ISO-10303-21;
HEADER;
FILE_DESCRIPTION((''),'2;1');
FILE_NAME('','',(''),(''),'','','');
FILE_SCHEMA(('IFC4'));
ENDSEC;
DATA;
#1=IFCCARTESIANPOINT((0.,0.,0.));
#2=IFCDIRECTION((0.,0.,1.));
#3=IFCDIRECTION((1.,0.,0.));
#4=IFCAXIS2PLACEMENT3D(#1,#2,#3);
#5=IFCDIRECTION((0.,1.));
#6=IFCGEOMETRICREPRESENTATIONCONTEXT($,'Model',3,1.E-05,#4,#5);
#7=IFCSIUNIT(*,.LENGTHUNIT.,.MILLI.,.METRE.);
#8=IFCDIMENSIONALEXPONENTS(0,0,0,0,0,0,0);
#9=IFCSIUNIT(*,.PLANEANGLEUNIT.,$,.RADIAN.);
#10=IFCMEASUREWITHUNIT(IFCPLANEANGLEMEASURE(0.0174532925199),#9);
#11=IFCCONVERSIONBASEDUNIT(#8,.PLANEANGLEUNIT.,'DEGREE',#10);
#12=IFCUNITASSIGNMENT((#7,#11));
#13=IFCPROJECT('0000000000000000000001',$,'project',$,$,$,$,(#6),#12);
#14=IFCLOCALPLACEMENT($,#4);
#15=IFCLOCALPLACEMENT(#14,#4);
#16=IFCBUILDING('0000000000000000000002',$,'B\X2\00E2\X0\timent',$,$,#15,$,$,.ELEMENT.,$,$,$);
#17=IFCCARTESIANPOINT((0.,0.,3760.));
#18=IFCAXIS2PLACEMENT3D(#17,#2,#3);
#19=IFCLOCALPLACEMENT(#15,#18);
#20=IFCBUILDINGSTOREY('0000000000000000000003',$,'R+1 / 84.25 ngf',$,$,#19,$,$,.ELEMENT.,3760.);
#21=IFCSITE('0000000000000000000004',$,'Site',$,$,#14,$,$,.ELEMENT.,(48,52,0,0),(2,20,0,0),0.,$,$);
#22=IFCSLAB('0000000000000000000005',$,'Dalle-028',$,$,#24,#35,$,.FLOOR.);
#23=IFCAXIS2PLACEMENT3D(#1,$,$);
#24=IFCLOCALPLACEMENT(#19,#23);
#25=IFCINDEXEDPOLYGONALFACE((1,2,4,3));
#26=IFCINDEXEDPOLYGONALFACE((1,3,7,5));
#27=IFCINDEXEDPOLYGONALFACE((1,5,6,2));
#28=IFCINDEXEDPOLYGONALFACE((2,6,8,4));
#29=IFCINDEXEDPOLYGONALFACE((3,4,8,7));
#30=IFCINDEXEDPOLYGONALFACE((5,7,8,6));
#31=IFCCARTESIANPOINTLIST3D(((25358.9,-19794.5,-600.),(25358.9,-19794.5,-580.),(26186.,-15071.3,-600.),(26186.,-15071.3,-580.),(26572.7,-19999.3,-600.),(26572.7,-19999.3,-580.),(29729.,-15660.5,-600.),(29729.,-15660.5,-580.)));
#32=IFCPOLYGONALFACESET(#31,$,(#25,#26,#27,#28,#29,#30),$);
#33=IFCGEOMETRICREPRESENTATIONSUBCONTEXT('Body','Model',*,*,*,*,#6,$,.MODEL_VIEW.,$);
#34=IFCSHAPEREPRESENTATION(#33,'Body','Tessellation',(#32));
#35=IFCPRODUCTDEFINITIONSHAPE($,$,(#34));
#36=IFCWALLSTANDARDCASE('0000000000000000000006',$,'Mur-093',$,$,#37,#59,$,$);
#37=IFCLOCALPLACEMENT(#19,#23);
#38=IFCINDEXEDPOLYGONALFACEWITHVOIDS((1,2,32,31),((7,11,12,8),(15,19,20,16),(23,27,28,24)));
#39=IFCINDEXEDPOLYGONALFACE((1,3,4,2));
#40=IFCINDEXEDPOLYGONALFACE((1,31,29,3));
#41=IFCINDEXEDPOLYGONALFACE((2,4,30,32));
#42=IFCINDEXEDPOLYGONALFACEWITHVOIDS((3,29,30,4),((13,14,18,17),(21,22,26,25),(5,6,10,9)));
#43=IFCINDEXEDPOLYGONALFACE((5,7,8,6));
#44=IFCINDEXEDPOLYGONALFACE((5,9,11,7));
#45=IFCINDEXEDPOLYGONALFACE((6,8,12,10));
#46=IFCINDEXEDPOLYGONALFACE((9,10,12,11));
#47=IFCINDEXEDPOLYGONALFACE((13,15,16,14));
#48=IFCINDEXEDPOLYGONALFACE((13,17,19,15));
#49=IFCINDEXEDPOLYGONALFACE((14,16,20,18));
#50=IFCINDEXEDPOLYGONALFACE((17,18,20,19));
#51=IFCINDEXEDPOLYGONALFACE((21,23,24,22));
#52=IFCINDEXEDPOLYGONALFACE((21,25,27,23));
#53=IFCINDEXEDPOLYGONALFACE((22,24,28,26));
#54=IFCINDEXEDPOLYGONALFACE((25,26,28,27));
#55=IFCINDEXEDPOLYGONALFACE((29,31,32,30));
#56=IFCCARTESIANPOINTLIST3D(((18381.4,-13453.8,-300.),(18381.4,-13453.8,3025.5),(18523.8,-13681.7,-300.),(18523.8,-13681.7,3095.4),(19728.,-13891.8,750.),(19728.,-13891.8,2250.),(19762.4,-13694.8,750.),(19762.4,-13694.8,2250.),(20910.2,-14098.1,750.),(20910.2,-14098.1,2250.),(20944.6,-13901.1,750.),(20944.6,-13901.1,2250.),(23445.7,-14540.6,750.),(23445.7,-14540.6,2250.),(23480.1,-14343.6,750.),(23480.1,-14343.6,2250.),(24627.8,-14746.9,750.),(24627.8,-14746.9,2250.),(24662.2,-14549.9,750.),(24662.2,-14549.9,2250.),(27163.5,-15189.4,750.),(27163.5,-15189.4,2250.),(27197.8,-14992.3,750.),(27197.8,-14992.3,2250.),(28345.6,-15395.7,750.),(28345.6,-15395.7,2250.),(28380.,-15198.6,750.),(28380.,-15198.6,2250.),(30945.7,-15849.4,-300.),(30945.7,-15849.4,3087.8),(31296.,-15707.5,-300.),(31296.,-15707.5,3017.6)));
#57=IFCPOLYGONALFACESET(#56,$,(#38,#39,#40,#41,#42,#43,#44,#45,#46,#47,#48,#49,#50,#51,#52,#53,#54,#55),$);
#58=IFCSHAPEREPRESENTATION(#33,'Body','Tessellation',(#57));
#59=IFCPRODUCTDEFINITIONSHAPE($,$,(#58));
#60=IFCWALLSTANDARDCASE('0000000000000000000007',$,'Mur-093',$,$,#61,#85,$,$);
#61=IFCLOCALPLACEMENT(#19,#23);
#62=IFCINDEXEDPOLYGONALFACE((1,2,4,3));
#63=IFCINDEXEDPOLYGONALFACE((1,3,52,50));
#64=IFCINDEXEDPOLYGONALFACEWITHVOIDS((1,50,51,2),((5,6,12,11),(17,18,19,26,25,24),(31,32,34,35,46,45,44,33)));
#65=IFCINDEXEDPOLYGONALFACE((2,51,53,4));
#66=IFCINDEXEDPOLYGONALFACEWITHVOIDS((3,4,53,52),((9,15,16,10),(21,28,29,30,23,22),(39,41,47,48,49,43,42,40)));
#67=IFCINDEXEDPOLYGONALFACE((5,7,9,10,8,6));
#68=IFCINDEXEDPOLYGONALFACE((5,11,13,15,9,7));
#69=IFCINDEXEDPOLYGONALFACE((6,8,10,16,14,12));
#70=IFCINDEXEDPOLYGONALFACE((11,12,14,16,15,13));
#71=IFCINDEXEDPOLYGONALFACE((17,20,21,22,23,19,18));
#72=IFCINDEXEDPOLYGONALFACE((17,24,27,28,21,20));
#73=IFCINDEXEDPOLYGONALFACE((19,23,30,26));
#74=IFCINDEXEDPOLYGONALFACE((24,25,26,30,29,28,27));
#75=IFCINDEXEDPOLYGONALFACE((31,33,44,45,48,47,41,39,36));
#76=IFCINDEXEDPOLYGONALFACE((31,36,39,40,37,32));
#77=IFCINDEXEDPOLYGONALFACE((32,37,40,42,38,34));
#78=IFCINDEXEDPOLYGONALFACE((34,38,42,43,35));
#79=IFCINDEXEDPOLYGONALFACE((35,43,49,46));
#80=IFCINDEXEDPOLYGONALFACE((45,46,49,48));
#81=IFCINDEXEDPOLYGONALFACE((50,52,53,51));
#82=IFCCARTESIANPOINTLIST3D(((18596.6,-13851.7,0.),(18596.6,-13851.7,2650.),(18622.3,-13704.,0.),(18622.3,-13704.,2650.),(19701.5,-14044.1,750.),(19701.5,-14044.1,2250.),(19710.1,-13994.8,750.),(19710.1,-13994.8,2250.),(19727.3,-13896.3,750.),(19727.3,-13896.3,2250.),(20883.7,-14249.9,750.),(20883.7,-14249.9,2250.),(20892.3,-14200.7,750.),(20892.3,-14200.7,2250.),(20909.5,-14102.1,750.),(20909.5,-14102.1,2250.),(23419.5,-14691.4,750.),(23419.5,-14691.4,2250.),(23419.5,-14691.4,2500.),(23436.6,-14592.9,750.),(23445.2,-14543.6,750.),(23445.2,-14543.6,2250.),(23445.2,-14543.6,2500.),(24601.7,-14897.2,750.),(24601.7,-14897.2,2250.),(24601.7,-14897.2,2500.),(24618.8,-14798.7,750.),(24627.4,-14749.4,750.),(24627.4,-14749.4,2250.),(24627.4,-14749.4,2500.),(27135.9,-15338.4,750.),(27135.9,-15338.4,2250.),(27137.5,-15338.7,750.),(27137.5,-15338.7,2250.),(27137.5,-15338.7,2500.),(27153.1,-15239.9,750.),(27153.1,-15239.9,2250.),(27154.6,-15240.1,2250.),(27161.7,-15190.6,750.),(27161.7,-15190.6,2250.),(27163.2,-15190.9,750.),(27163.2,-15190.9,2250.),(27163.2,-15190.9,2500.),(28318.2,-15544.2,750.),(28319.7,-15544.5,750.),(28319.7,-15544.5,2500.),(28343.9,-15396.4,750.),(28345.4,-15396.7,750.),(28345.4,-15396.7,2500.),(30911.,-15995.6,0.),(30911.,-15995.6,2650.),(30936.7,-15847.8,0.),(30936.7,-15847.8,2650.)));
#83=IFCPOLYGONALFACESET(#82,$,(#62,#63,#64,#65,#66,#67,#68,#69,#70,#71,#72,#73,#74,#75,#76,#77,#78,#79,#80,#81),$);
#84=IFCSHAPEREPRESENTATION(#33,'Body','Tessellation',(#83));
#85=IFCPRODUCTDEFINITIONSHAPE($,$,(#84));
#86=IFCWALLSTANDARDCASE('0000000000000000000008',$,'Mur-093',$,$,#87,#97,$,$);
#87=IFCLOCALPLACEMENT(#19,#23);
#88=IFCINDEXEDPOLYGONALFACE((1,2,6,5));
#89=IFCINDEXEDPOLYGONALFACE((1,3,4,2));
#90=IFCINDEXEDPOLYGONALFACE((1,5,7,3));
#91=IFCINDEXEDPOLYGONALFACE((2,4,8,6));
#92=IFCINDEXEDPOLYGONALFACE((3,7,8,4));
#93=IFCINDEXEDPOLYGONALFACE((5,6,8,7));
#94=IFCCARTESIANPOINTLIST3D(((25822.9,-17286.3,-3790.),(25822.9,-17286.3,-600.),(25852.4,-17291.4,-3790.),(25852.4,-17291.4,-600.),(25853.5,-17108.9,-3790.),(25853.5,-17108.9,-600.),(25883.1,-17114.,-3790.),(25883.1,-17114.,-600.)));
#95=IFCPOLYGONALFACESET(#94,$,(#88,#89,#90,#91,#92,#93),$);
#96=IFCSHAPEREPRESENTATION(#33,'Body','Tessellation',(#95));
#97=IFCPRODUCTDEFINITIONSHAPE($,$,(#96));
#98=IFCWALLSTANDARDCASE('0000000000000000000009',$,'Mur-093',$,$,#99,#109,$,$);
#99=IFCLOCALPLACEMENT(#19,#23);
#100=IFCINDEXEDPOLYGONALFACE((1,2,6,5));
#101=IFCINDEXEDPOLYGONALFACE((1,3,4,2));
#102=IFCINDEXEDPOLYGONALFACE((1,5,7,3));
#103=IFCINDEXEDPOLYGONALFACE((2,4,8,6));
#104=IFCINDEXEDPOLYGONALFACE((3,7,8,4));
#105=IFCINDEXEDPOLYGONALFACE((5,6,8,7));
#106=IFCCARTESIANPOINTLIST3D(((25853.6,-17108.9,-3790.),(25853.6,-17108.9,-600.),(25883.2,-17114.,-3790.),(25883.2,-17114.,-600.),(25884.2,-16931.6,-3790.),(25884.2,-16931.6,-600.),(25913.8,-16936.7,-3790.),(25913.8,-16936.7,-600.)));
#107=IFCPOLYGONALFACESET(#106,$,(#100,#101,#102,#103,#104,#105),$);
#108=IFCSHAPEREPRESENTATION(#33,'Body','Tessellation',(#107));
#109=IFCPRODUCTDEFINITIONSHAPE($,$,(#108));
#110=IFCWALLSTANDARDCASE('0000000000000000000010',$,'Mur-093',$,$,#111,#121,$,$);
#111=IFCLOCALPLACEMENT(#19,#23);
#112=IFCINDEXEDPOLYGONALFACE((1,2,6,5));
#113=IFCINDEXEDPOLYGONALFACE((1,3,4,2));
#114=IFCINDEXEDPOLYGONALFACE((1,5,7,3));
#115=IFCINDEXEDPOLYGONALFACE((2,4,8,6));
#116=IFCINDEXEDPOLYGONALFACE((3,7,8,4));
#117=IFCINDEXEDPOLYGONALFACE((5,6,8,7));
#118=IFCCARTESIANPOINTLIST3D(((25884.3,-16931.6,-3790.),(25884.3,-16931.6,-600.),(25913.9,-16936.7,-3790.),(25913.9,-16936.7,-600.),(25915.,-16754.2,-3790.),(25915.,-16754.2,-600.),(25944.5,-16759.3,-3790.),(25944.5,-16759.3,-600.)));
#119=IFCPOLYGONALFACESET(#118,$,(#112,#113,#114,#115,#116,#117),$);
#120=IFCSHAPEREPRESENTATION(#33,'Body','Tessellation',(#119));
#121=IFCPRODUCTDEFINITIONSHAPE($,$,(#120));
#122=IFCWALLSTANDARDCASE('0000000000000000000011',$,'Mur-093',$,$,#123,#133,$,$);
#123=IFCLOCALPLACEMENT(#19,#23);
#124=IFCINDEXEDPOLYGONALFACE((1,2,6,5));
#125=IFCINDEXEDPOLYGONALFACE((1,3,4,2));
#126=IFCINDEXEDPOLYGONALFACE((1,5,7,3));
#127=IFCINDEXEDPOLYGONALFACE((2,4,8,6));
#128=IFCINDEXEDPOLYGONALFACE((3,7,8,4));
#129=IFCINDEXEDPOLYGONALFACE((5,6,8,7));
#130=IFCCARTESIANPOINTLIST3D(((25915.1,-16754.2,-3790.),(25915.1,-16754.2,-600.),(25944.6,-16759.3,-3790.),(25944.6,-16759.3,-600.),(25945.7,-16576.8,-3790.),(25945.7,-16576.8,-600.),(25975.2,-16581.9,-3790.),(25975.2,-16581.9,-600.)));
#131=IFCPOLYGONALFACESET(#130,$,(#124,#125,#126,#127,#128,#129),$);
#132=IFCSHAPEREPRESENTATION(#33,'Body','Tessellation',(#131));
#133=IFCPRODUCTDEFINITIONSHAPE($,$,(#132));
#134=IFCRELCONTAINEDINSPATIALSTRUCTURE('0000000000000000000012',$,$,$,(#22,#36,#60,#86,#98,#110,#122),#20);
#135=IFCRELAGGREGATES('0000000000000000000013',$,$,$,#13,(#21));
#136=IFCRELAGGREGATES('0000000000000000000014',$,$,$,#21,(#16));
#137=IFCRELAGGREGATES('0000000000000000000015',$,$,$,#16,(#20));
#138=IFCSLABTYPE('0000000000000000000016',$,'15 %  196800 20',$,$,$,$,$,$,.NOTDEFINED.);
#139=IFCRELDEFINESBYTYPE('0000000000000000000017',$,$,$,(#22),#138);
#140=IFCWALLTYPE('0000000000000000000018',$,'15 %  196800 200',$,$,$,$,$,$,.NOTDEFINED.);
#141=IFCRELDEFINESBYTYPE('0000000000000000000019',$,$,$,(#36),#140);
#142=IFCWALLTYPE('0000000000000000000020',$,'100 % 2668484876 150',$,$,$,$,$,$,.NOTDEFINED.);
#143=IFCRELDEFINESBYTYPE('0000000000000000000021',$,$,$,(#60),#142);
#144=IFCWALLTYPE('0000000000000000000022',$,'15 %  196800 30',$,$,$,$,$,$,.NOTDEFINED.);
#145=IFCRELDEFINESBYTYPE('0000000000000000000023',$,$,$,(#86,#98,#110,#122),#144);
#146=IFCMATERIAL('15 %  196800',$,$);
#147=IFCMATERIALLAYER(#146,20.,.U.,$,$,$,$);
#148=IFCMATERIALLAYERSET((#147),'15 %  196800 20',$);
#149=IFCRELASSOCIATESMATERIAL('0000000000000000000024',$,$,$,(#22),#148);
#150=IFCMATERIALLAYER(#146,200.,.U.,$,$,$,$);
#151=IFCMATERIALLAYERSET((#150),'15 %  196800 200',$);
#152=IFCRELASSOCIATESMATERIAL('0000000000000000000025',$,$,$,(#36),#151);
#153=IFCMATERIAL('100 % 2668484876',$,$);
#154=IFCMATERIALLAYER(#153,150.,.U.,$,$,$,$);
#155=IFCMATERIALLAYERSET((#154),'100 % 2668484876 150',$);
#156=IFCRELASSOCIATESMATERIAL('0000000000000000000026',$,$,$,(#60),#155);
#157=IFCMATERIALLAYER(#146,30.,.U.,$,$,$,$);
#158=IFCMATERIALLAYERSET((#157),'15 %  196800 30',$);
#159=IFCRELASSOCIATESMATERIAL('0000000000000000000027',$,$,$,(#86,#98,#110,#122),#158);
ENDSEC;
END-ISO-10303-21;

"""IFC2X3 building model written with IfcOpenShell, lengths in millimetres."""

from ifc_helpers import new_model, entity, si_unit, converted_unit, direction, frame, origin_with_axes, origin_2d_with_axis, place, context, subcontext, project, spatial, polyline, rectangle, outline, extrude, clip, halfspace, material, layer, layer_set, layer_usage, type_object, element, save


model = new_model("IFC2X3")

# Units and contexts
model_context = context("Model", 3, precision=1e-05, world=origin_with_axes(), true_north=direction((0.0, 1.0)))
body_context = subcontext(model_context, "Body", "Model", "MODEL_VIEW")
ifc_project = project(units=[si_unit("LENGTHUNIT", "METRE", prefix="MILLI"), converted_unit("PLANEANGLEUNIT", "DEGREE", entity("IfcPlaneAngleMeasure", 0.0174532925199), si_unit("PLANEANGLEUNIT", "RADIAN"), dimensions=[0, 0, 0, 0, 0, 0, 0])], contexts=[model_context])

# Site, building, storey
site_placement = place(None, origin_with_axes())
site = spatial("IfcSite", under=ifc_project, at=site_placement, Name="Site", CompositionType="ELEMENT", RefLatitude=(48, 52, 0, 0), RefLongitude=(2, 20, 0, 0), RefElevation=0.0)
building_placement = place(site_placement, origin_with_axes())
building = spatial("IfcBuilding", under=site, at=building_placement, Name="Bâtiment", CompositionType="ELEMENT")
storey_placement = place(building_placement, frame((0.0, 0.0, 3760.0), z_axis=(0.0, 0.0, 1.0), x_axis=(1.0, 0.0, 0.0)))
storey = spatial("IfcBuildingStorey", under=building, at=storey_placement, Name="R+1 / 84.25 ngf", CompositionType="ELEMENT", Elevation=3760.0)

# Slab
ifc_material_1 = material(Name="15 %  196800")
ifc_layer_1 = layer(ifc_material_1, 20.0, ventilated="UNKNOWN")
ifc_layer_set_1 = layer_set([ifc_layer_1], Name="15 %  196800 20")
ifc_layer_usage_1 = layer_usage(ifc_layer_set_1, "AXIS3", "NEGATIVE", 20.0)
slab_type = type_object("IfcSlabType", Name="15 %  196800 20", PredefinedType="NOTDEFINED")
slab_placement = place(storey_placement, frame((26186.0, -15071.3, -580.0), z_axis=(0.0, 0.0, 1.0), x_axis=(1.0, 0.0, 0.0)))
element("IfcSlab", 1, at=slab_placement, inside=storey, type_object=slab_type, material=ifc_layer_usage_1, Name="Dalle-028", PredefinedType="FLOOR", context=body_context, shape_type="SweptSolid", body=[
    extrude(outline(polyline([(0.0, 0.0), (-827.0, -4723.2), (386.7, -4928.0), (3543.0, -589.2), (0.0, 0.0)])), frame((0.0, 0.0, -20.0), z_axis=(0.0, 0.0, 1.0), x_axis=(1.0, 0.0, 0.0)), (0.0, 0.0, 1.0), 20.0),
])

# Walls, openings
ifc_layer_2 = layer(ifc_material_1, 200.0, ventilated="UNKNOWN")
ifc_layer_set_2 = layer_set([ifc_layer_2], Name="15 %  196800 200")
ifc_layer_usage_2 = layer_usage(ifc_layer_set_2, "AXIS2", "NEGATIVE", 200.0)
wall_type_1 = type_object("IfcWallType", Name="15 %  196800 200", PredefinedType="NOTDEFINED")
wall_1_placement = place(storey_placement, frame((31296.0, -15707.5, -300.0), z_axis=(0.0, 0.0, 1.0), x_axis=(-0.985113, 0.17191, 0.0)))
wall_1 = element("IfcWallStandardCase", 2, at=wall_1_placement, inside=storey, type_object=wall_type_1, material=ifc_layer_usage_2, Name="Mur-093", context=body_context, shape_type="Clipping", body=[
    clip(extrude(outline(polyline([(0.0, 0.0), (13109.8, 0.0), (12930.4, 200.0), (320.7, 200.0), (0.0, 0.0)])), origin_with_axes(), (0.0, 0.0, 1.0), 3440.0), halfspace(frame((-1.8, -1034.5, 2955.6), z_axis=(0.000566, 0.33035, -0.943858), x_axis=(0.0, 0.943859, 0.33035)), True)),
])
opening_1_placement = place(wall_1_placement, frame((3560.1, 0.0, 1050.0), z_axis=(0.0, 0.0, 1.0), x_axis=(1.0, 0.0, 0.0)))
element("IfcOpeningElement", 3, at=opening_1_placement, cuts=wall_1, context=body_context, shape_type="SweptSolid", body=[
    extrude(rectangle(XDim=1200.0, YDim=1500.0, at=origin_2d_with_axis()), frame((0.0, 400.0, 750.0), z_axis=(0.0, -1.0, 0.0), x_axis=(1.0, 0.0, 0.0)), (0.0, 0.0, 1.0), 600.0),
    extrude(rectangle(XDim=1500.0, YDim=1800.0, at=origin_2d_with_axis()), frame((0.0, -200.0, 750.0), z_axis=(0.0, 1.0, 0.0), x_axis=(1.0, 0.0, 0.0)), (0.0, 0.0, 1.0), 200.0),
])
opening_2_placement = place(wall_1_placement, frame((11107.9, 0.0, 1050.0), z_axis=(0.0, 0.0, 1.0), x_axis=(1.0, 0.0, 0.0)))
element("IfcOpeningElement", 4, at=opening_2_placement, cuts=wall_1, context=body_context, shape_type="SweptSolid", body=[
    extrude(rectangle(XDim=1200.0, YDim=1500.0, at=origin_2d_with_axis()), frame((0.0, 400.0, 750.0), z_axis=(0.0, -1.0, 0.0), x_axis=(1.0, 0.0, 0.0)), (0.0, 0.0, 1.0), 600.0),
    extrude(rectangle(XDim=1500.0, YDim=1800.0, at=origin_2d_with_axis()), frame((0.0, -200.0, 750.0), z_axis=(0.0, 1.0, 0.0), x_axis=(1.0, 0.0, 0.0)), (0.0, 0.0, 1.0), 200.0),
])
opening_3_placement = place(wall_1_placement, frame((7334.1, 0.0, 1050.0), z_axis=(0.0, 0.0, 1.0), x_axis=(1.0, 0.0, 0.0)))
element("IfcOpeningElement", 5, at=opening_3_placement, cuts=wall_1, context=body_context, shape_type="SweptSolid", body=[
    extrude(rectangle(XDim=1200.0, YDim=1500.0, at=origin_2d_with_axis()), frame((0.0, 400.0, 750.0), z_axis=(0.0, -1.0, 0.0), x_axis=(1.0, 0.0, 0.0)), (0.0, 0.0, 1.0), 600.0),
    extrude(rectangle(XDim=1500.0, YDim=1800.0, at=origin_2d_with_axis()), frame((0.0, -200.0, 750.0), z_axis=(0.0, 1.0, 0.0), x_axis=(1.0, 0.0, 0.0)), (0.0, 0.0, 1.0), 200.0),
])
ifc_material_2 = material(Name="100 % 2668484876")
ifc_layer_3 = layer(ifc_material_2, 150.0, ventilated="UNKNOWN")
ifc_layer_set_3 = layer_set([ifc_layer_3], Name="100 % 2668484876 150")
ifc_layer_usage_3 = layer_usage(ifc_layer_set_3, "AXIS2", "NEGATIVE", 150.0)
wall_type_2 = type_object("IfcWallType", Name="100 % 2668484876 150", PredefinedType="NOTDEFINED")
wall_2_placement = place(storey_placement, frame((30936.7, -15847.8, 0.0), z_axis=(0.0, 0.0, 1.0), x_axis=(-0.985181, 0.171516, 0.0)))
wall_2 = element("IfcWallStandardCase", 6, at=wall_2_placement, inside=storey, type_object=wall_type_2, material=ifc_layer_usage_3, Name="Mur-093", context=body_context, shape_type="SweptSolid", body=[
    extrude(outline(polyline([(0.0, 0.0), (12499.6, 0.0), (12499.6, 150.0), (0.0, 150.0), (0.0, 0.0)])), origin_with_axes(), (0.0, 0.0, 1.0), 2650.0),
])
opening_4_placement = place(wall_2_placement, frame((3231.9, 0.0, 750.0), z_axis=(0.0, 0.0, 1.0), x_axis=(1.0, 0.0, 0.0)))
element("IfcOpeningElement", 7, at=opening_4_placement, cuts=wall_2, context=body_context, shape_type="SweptSolid", body=[
    extrude(rectangle(XDim=1200.0, YDim=1500.0, at=origin_2d_with_axis()), frame((0.0, 300.0, 750.0), z_axis=(0.0, -1.0, 0.0), x_axis=(1.0, 0.0, 0.0)), (0.0, 0.0, 1.0), 250.0),
    extrude(rectangle(XDim=1200.0, YDim=1500.0, at=origin_2d_with_axis()), frame((0.0, -150.0, 750.0), z_axis=(0.0, 1.0, 0.0), x_axis=(1.0, 0.0, 0.0)), (0.0, 0.0, 1.0), 200.0),
])
opening_5_placement = place(wall_2_placement, frame((7004.2, 0.0, 750.0), z_axis=(0.0, 0.0, 1.0), x_axis=(1.0, 0.0, 0.0)))
element("IfcOpeningElement", 8, at=opening_5_placement, cuts=wall_2, context=body_context, shape_type="SweptSolid", body=[
    extrude(rectangle(XDim=1200.0, YDim=1500.0, at=origin_2d_with_axis()), frame((0.0, 300.0, 750.0), z_axis=(0.0, 1.0, 0.0), x_axis=(-1.0, 0.0, 0.0)), (0.0, 0.0, -1.0), 250.0),
    extrude(rectangle(XDim=1200.0, YDim=1500.0, at=origin_2d_with_axis()), frame((0.0, -150.0, 750.0), z_axis=(0.0, -1.0, 0.0), x_axis=(-1.0, 0.0, 0.0)), (0.0, 0.0, -1.0), 200.0),
])
opening_6_placement = place(wall_2_placement, frame((3230.3, 0.0, 750.0), z_axis=(0.0, 0.0, 1.0), x_axis=(1.0, 0.0, 0.0)))
element("IfcOpeningElement", 9, at=opening_6_placement, cuts=wall_2, context=body_context, shape_type="SweptSolid", body=[
    extrude(rectangle(XDim=1200.0, YDim=1750.0, at=origin_2d_with_axis()), frame((0.0, 300.0, 875.0), z_axis=(0.0, -1.0, 0.0), x_axis=(1.0, 0.0, 0.0)), (0.0, 0.0, 1.0), 450.0),
])
opening_7_placement = place(wall_2_placement, frame((10778.1, 0.0, 750.0), z_axis=(0.0, 0.0, 1.0), x_axis=(1.0, 0.0, 0.0)))
element("IfcOpeningElement", 10, at=opening_7_placement, cuts=wall_2, context=body_context, shape_type="SweptSolid", body=[
    extrude(rectangle(XDim=1200.0, YDim=1500.0, at=origin_2d_with_axis()), frame((0.0, -150.0, 750.0), z_axis=(0.0, 1.0, 0.0), x_axis=(1.0, 0.0, 0.0)), (0.0, 0.0, 1.0), 250.0),
    extrude(rectangle(XDim=1200.0, YDim=1500.0, at=origin_2d_with_axis()), frame((0.0, 300.0, 750.0), z_axis=(0.0, -1.0, 0.0), x_axis=(1.0, 0.0, 0.0)), (0.0, 0.0, 1.0), 200.0),
])
opening_8_placement = place(wall_2_placement, frame((7004.2, 0.0, 750.0), z_axis=(0.0, 0.0, 1.0), x_axis=(1.0, 0.0, 0.0)))
element("IfcOpeningElement", 11, at=opening_8_placement, cuts=wall_2, context=body_context, shape_type="SweptSolid", body=[
    extrude(rectangle(XDim=1200.0, YDim=1750.0, at=origin_2d_with_axis()), frame((0.0, 300.0, 875.0), z_axis=(0.0, -1.0, 0.0), x_axis=(1.0, 0.0, 0.0)), (0.0, 0.0, 1.0), 450.0),
])

# Walls
ifc_layer_4 = layer(ifc_material_1, 30.0, ventilated="UNKNOWN")
ifc_layer_set_4 = layer_set([ifc_layer_4], Name="15 %  196800 30")
ifc_layer_usage_4 = layer_usage(ifc_layer_set_4, "AXIS2", "NEGATIVE", 30.0)
wall_type_3 = type_object("IfcWallType", Name="15 %  196800 30", PredefinedType="NOTDEFINED")
wall_3_placement = place(storey_placement, frame((25853.5, -17108.9, -3790.0), z_axis=(0.0, 0.0, 1.0), x_axis=(-0.170069, -0.985432, 0.0)))
element("IfcWallStandardCase", 12, at=wall_3_placement, inside=storey, type_object=wall_type_3, material=ifc_layer_usage_4, Name="Mur-093", context=body_context, shape_type="SweptSolid", body=[
    extrude(outline(polyline([(0.0, 0.0), (180.0, 0.0), (180.0, 30.0), (0.0, 30.0), (0.0, 0.0)])), origin_with_axes(), (0.0, 0.0, 1.0), 3190.0),
])
ifc_layer_usage_5 = layer_usage(ifc_layer_set_4, "AXIS2", "NEGATIVE", 30.0)
wall_4_placement = place(storey_placement, frame((25884.2, -16931.6, -3790.0), z_axis=(0.0, 0.0, 1.0), x_axis=(-0.170069, -0.985432, 0.0)))
element("IfcWallStandardCase", 13, at=wall_4_placement, inside=storey, type_object=wall_type_3, material=ifc_layer_usage_5, Name="Mur-093", context=body_context, shape_type="SweptSolid", body=[
    extrude(outline(polyline([(0.0, 0.0), (180.0, 0.0), (180.0, 30.0), (0.0, 30.0), (0.0, 0.0)])), origin_with_axes(), (0.0, 0.0, 1.0), 3190.0),
])
ifc_layer_usage_6 = layer_usage(ifc_layer_set_4, "AXIS2", "NEGATIVE", 30.0)
wall_5_placement = place(storey_placement, frame((25915.0, -16754.2, -3790.0), z_axis=(0.0, 0.0, 1.0), x_axis=(-0.170069, -0.985432, 0.0)))
element("IfcWallStandardCase", 14, at=wall_5_placement, inside=storey, type_object=wall_type_3, material=ifc_layer_usage_6, Name="Mur-093", context=body_context, shape_type="SweptSolid", body=[
    extrude(outline(polyline([(0.0, 0.0), (180.0, 0.0), (180.0, 30.0), (0.0, 30.0), (0.0, 0.0)])), origin_with_axes(), (0.0, 0.0, 1.0), 3190.0),
])
ifc_layer_usage_7 = layer_usage(ifc_layer_set_4, "AXIS2", "NEGATIVE", 30.0)
wall_6_placement = place(storey_placement, frame((25945.7, -16576.8, -3790.0), z_axis=(0.0, 0.0, 1.0), x_axis=(-0.170069, -0.985432, 0.0)))
element("IfcWallStandardCase", 15, at=wall_6_placement, inside=storey, type_object=wall_type_3, material=ifc_layer_usage_7, Name="Mur-093", context=body_context, shape_type="SweptSolid", body=[
    extrude(outline(polyline([(0.0, 0.0), (180.0, 0.0), (180.0, 30.0), (0.0, 30.0), (0.0, 0.0)])), origin_with_axes(), (0.0, 0.0, 1.0), 3190.0),
])

save(model, "model.ifc")
